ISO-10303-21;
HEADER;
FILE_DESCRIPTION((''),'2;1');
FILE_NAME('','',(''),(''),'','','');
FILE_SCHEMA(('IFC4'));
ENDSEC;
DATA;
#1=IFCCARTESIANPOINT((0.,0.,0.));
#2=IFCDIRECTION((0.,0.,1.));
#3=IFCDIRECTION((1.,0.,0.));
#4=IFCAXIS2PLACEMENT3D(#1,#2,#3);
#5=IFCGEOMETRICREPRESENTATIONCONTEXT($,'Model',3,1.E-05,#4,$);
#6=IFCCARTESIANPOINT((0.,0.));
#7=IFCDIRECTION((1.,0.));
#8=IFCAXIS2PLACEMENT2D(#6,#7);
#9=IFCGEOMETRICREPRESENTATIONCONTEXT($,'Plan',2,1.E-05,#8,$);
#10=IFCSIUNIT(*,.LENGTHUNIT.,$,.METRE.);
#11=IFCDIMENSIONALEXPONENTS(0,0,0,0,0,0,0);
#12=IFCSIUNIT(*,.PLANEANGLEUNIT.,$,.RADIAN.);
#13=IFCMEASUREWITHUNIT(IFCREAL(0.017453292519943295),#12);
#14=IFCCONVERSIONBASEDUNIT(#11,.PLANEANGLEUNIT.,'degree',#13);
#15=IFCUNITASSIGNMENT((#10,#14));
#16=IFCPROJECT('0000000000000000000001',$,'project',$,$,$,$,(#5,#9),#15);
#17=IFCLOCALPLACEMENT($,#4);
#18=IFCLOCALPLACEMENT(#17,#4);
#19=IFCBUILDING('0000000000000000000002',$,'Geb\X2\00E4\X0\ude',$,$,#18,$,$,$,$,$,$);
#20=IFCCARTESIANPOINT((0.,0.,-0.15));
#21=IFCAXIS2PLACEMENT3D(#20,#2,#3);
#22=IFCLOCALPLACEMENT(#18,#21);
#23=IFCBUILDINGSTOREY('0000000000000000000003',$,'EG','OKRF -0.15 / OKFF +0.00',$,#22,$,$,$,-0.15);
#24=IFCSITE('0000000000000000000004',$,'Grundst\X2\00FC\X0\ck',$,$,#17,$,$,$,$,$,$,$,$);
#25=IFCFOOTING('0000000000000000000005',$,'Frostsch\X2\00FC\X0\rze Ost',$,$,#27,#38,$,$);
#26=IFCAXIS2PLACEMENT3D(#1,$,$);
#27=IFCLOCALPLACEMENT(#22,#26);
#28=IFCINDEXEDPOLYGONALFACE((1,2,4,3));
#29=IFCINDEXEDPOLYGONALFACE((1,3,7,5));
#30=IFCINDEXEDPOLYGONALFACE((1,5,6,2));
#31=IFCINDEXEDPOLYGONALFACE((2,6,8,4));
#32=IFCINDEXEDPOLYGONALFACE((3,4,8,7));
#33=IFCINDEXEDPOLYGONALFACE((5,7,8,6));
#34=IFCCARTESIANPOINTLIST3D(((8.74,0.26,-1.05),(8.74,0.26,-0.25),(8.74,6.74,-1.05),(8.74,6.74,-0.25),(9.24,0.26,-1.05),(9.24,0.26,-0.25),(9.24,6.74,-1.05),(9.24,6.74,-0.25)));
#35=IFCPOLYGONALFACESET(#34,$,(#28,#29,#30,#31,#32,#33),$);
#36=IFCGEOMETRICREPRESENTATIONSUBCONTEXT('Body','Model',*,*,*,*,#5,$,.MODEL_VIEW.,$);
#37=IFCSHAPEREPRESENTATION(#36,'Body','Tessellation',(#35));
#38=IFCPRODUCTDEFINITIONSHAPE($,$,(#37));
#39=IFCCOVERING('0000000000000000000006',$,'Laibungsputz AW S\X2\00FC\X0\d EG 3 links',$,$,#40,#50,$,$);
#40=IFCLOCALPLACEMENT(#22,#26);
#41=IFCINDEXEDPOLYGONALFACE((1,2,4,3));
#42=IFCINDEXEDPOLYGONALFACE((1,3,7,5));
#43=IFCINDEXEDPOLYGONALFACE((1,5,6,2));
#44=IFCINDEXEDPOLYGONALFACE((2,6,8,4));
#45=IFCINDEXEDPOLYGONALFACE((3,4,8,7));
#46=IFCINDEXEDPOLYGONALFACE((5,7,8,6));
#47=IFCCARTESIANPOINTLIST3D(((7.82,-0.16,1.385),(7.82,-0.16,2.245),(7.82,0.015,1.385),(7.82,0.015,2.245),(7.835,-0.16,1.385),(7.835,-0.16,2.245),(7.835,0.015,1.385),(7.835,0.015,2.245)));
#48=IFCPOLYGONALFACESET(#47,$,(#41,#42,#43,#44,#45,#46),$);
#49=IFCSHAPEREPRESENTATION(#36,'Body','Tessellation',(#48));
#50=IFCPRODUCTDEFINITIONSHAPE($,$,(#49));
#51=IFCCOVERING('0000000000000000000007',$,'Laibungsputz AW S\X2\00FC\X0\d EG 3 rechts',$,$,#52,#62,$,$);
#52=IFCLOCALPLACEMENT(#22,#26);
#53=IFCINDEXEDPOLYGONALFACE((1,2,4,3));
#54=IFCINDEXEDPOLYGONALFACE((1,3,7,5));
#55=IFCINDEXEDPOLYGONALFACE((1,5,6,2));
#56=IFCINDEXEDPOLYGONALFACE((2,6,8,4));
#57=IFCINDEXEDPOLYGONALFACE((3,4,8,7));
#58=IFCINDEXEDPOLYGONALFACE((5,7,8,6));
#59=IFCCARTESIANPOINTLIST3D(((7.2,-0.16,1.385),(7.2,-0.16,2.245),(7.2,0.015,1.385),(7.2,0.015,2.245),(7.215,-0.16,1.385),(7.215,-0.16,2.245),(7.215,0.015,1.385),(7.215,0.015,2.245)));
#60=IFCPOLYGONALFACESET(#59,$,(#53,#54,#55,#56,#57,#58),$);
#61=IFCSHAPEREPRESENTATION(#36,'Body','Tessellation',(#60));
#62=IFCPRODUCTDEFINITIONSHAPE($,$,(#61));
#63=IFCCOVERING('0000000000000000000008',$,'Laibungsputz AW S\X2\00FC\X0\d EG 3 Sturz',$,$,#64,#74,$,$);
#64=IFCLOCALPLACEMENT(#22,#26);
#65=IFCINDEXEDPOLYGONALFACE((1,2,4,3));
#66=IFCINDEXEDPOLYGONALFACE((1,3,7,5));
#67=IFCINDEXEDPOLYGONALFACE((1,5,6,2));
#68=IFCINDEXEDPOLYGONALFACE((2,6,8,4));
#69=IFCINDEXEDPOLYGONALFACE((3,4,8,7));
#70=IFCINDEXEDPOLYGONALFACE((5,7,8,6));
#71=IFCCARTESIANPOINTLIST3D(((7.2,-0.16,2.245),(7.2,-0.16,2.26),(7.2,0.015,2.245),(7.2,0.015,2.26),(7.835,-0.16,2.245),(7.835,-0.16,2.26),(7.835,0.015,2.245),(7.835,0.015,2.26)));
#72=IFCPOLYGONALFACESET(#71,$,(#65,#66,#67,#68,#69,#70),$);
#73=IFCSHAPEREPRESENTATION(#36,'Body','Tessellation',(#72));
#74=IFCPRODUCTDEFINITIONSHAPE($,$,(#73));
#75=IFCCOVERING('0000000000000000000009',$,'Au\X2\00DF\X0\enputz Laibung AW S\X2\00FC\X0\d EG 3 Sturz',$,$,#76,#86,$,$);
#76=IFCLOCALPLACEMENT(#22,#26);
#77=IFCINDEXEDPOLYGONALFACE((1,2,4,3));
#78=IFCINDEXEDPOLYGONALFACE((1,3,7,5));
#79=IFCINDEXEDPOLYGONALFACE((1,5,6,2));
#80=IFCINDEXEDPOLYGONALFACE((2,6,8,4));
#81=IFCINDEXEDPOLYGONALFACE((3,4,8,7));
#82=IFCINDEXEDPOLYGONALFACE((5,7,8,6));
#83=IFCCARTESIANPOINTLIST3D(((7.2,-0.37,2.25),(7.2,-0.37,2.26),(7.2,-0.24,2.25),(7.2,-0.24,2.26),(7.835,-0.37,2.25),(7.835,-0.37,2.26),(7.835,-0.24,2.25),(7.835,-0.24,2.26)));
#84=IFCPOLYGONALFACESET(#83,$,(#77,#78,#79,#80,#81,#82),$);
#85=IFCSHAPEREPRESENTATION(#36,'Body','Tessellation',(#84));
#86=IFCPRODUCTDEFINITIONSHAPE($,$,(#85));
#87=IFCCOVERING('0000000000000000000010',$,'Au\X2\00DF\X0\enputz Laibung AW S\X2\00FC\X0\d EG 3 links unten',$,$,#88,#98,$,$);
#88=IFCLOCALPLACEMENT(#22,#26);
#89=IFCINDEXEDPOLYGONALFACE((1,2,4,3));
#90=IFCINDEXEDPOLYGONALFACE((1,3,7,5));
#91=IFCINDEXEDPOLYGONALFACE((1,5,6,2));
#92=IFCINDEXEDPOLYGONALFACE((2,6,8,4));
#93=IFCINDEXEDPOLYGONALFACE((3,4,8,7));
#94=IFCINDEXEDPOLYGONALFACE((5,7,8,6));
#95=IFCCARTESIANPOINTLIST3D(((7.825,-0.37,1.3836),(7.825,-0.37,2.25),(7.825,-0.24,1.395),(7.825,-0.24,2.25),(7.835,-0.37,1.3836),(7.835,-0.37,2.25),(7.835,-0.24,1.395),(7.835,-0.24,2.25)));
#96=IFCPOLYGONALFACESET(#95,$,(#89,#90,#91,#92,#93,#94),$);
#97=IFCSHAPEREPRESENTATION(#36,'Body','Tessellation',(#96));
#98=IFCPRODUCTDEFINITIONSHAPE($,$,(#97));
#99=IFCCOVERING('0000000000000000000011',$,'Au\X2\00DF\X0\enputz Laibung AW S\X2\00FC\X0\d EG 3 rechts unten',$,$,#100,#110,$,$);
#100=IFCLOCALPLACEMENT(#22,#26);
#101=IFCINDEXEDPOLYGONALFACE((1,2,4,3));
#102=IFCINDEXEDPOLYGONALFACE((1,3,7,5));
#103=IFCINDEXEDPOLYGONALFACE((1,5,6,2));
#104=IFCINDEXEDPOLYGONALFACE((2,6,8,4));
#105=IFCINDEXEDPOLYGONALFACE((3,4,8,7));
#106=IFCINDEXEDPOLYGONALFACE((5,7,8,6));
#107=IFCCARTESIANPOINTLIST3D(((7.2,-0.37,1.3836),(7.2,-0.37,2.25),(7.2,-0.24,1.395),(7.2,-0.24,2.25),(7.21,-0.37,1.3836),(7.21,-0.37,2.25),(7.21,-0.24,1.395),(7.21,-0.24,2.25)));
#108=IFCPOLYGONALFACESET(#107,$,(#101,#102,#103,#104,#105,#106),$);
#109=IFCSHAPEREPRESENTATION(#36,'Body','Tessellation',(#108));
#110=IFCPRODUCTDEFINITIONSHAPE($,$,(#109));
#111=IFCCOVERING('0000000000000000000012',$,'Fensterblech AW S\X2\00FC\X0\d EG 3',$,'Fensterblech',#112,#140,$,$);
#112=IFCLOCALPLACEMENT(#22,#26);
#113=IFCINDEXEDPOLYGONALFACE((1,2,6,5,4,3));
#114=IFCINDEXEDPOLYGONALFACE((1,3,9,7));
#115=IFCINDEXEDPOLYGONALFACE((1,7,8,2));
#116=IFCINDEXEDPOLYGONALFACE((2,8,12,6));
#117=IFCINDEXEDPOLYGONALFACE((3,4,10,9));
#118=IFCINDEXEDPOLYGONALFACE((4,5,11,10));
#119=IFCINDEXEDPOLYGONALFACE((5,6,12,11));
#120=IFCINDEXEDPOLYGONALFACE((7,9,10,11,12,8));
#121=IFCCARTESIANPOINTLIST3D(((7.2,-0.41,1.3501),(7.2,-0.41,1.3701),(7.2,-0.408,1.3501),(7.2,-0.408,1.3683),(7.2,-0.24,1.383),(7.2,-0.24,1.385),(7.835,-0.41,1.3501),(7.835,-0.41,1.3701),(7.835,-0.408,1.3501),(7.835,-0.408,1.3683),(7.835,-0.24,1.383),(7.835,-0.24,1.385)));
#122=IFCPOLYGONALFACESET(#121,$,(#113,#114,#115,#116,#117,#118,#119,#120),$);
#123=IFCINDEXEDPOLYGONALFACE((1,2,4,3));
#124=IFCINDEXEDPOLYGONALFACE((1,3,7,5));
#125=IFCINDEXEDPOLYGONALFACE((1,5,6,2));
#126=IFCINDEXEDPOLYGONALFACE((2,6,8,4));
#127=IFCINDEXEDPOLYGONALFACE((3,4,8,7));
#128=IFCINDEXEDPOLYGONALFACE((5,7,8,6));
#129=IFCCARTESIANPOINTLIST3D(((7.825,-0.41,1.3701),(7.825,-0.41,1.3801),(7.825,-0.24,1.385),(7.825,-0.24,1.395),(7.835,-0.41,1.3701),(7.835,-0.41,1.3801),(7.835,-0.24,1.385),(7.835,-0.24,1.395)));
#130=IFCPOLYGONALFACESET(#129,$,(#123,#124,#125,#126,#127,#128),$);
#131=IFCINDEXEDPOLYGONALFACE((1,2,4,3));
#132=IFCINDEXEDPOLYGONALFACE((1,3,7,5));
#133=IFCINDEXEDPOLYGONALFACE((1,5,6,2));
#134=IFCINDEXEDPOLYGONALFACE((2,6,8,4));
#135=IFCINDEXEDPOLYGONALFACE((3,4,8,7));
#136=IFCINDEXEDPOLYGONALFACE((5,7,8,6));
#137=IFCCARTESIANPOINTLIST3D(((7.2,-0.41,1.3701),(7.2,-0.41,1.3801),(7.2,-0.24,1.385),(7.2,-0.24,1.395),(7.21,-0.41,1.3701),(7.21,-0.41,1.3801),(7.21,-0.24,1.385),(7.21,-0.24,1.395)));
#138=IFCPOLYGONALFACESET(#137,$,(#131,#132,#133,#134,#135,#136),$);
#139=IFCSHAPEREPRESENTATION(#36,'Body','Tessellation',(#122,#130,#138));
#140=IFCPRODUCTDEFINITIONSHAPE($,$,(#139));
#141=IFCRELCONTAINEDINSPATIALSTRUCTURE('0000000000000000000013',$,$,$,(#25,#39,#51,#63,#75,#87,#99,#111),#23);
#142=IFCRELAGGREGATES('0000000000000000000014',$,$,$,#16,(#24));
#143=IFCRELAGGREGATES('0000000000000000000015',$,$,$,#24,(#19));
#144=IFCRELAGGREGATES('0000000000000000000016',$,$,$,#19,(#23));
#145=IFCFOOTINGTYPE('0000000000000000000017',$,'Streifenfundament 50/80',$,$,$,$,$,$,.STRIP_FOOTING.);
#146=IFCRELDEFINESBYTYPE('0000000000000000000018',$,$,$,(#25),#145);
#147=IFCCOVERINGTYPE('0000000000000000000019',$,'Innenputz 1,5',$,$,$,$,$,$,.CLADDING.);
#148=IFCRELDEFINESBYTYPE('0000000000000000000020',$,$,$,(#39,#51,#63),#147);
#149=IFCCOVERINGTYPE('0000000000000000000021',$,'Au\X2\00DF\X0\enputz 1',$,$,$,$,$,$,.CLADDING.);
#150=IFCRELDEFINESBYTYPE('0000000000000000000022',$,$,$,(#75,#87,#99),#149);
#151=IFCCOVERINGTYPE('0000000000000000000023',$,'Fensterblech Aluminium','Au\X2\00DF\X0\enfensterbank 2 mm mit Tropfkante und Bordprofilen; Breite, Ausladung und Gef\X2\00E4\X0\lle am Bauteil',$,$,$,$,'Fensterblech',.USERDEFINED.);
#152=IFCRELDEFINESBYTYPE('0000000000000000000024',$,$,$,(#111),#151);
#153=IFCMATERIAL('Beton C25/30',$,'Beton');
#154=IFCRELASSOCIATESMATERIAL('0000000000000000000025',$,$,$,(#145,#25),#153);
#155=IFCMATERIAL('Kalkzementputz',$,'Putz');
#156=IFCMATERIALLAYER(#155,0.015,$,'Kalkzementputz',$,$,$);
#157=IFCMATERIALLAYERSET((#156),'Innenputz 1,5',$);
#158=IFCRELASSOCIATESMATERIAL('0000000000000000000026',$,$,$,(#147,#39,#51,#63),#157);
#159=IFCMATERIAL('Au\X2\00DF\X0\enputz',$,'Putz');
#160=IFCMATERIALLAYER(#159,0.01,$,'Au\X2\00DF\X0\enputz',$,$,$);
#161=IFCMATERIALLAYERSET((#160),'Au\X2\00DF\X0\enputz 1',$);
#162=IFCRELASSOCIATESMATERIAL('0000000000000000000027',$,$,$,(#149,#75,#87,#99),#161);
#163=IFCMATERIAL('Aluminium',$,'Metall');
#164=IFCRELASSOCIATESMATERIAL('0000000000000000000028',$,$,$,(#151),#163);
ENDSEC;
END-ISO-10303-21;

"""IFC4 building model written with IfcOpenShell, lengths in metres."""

from ifc_helpers import new_model, entity, si_unit, converted_unit, frame, origin_with_axes, origin_2d_with_axis, place, context, subcontext, project, spatial, polyline, rectangle, outline, extrude, material, layer, layer_set, layer_usage, material_profile, profile_set, profile_usage, type_object, element, save


model = new_model("IFC4")

# Units and contexts
model_context = context("Model", 3, precision=1e-05, world=origin_with_axes())
plan_context = context("Plan", 2, precision=1e-05, world=origin_2d_with_axis())
body_context_1 = subcontext(model_context, "Body", "Model", "MODEL_VIEW")
ifc_project = project(units=[si_unit("LENGTHUNIT", "METRE"), converted_unit("PLANEANGLEUNIT", "degree", entity("IfcReal", 0.017453292519943295), si_unit("PLANEANGLEUNIT", "RADIAN"), dimensions=[0, 0, 0, 0, 0, 0, 0])], contexts=[model_context, plan_context])

# Site, building, storey
site_placement = place(None, origin_with_axes())
site = spatial("IfcSite", under=ifc_project, at=site_placement, Name="Grundstück")
building_placement = place(site_placement, origin_with_axes())
building = spatial("IfcBuilding", under=site, at=building_placement, Name="Gebäude")
storey_placement = place(building_placement, frame((0.0, 0.0, -0.15), z_axis=(0.0, 0.0, 1.0), x_axis=(1.0, 0.0, 0.0)))
storey = spatial("IfcBuildingStorey", under=building, at=storey_placement, Name="EG", Description="OKRF -0.15 / OKFF +0.00", Elevation=-0.15)

# Footing
ifc_material_1 = material(Name="Beton C25/30", Category="Beton")
ifc_material_profile = material_profile(ifc_material_1, rectangle(XDim=0.5, YDim=0.8))
ifc_profile_set = profile_set([ifc_material_profile], Name="Streifenfundament 50/80")
ifc_profile_usage = profile_usage(ifc_profile_set)
footing_type = type_object("IfcFootingType", Name="Streifenfundament 50/80", PredefinedType="STRIP_FOOTING", material=ifc_profile_set)
footing_placement = place(storey_placement, frame((8.99, 0.26, -0.65), z_axis=(0.0, 1.0, 0.0), x_axis=(-1.0, 0.0, 0.0)))
element("IfcFooting", 1, at=footing_placement, inside=storey, type_object=footing_type, material=ifc_profile_usage, Name="Frostschürze Ost", context=body_context_1, shape_type="SweptSolid", body=[
    extrude(rectangle(XDim=0.5, YDim=0.8), origin_with_axes(), (0.0, 0.0, 1.0), 6.48),
])

# Coverings
ifc_material_2 = material(Name="Kalkzementputz", Category="Putz")
ifc_layer_1 = layer(ifc_material_2, 0.015, Name="Kalkzementputz")
ifc_layer_set_1 = layer_set([ifc_layer_1], Name="Innenputz 1,5")
ifc_layer_usage_1 = layer_usage(ifc_layer_set_1, "AXIS1", "POSITIVE", 1.165)
covering_type_1 = type_object("IfcCoveringType", Name="Innenputz 1,5", PredefinedType="CLADDING", material=ifc_layer_set_1)
covering_1_placement = place(storey_placement, frame((9.0, 0.0, 0.0), z_axis=(0.0, 0.0, 1.0), x_axis=(-1.0, 0.0, 0.0)))
element("IfcCovering", 2, at=covering_1_placement, inside=storey, type_object=covering_type_1, material=ifc_layer_usage_1, Name="Laibungsputz AW Süd EG 3 links", context=body_context_1, shape_type="SweptSolid", body=[
    extrude(outline(polyline([(-0.015, 1.385), (0.16, 1.385), (0.16, 2.245), (-0.015, 2.245), (-0.015, 1.385)])), frame((1.165, 0.0, 0.0), z_axis=(1.0, 0.0, 0.0), x_axis=(0.0, 1.0, 0.0)), (0.0, 0.0, 1.0), 0.015),
])
ifc_layer_usage_2 = layer_usage(ifc_layer_set_1, "AXIS1", "POSITIVE", 1.785)
covering_2_placement = place(storey_placement, frame((9.0, 0.0, 0.0), z_axis=(0.0, 0.0, 1.0), x_axis=(-1.0, 0.0, 0.0)))
element("IfcCovering", 3, at=covering_2_placement, inside=storey, type_object=covering_type_1, material=ifc_layer_usage_2, Name="Laibungsputz AW Süd EG 3 rechts", context=body_context_1, shape_type="SweptSolid", body=[
    extrude(outline(polyline([(-0.015, 1.385), (0.16, 1.385), (0.16, 2.245), (-0.015, 2.245), (-0.015, 1.385)])), frame((1.785, 0.0, 0.0), z_axis=(1.0, 0.0, 0.0), x_axis=(0.0, 1.0, 0.0)), (0.0, 0.0, 1.0), 0.015),
])
ifc_layer_usage_3 = layer_usage(ifc_layer_set_1, "AXIS3", "POSITIVE", 2.245)
covering_3_placement = place(storey_placement, frame((9.0, 0.0, 0.0), z_axis=(0.0, 0.0, 1.0), x_axis=(-1.0, 0.0, 0.0)))
element("IfcCovering", 4, at=covering_3_placement, inside=storey, type_object=covering_type_1, material=ifc_layer_usage_3, Name="Laibungsputz AW Süd EG 3 Sturz", context=body_context_1, shape_type="SweptSolid", body=[
    extrude(outline(polyline([(-0.015, 2.245), (0.16, 2.245), (0.16, 2.26), (-0.015, 2.26), (-0.015, 2.245)])), frame((1.165, 0.0, 0.0), z_axis=(1.0, 0.0, 0.0), x_axis=(0.0, 1.0, 0.0)), (0.0, 0.0, 1.0), 0.635),
])
ifc_material_3 = material(Name="Außenputz", Category="Putz")
ifc_layer_2 = layer(ifc_material_3, 0.01, Name="Außenputz")
ifc_layer_set_2 = layer_set([ifc_layer_2], Name="Außenputz 1")
ifc_layer_usage_4 = layer_usage(ifc_layer_set_2, "AXIS3", "POSITIVE", 2.25)
covering_type_2 = type_object("IfcCoveringType", Name="Außenputz 1", PredefinedType="CLADDING", material=ifc_layer_set_2)
covering_4_placement = place(storey_placement, frame((9.0, 0.0, 0.0), z_axis=(0.0, 0.0, 1.0), x_axis=(-1.0, 0.0, 0.0)))
element("IfcCovering", 5, at=covering_4_placement, inside=storey, type_object=covering_type_2, material=ifc_layer_usage_4, Name="Außenputz Laibung AW Süd EG 3 Sturz", context=body_context_1, shape_type="SweptSolid", body=[
    extrude(outline(polyline([(0.24, 2.25), (0.37, 2.25), (0.37, 2.26), (0.24, 2.26), (0.24, 2.25)])), frame((1.165, 0.0, 0.0), z_axis=(1.0, 0.0, 0.0), x_axis=(0.0, 1.0, 0.0)), (0.0, 0.0, 1.0), 0.635),
])
ifc_layer_usage_5 = layer_usage(ifc_layer_set_2, "AXIS1", "POSITIVE", 1.165)
covering_5_placement = place(storey_placement, frame((9.0, 0.0, 0.0), z_axis=(0.0, 0.0, 1.0), x_axis=(-1.0, 0.0, 0.0)))
element("IfcCovering", 6, at=covering_5_placement, inside=storey, type_object=covering_type_2, material=ifc_layer_usage_5, Name="Außenputz Laibung AW Süd EG 3 links unten", context=body_context_1, shape_type="SweptSolid", body=[
    extrude(outline(polyline([(0.24, 1.395), (0.37, 1.3836), (0.37, 2.25), (0.24, 2.25), (0.24, 1.395)])), frame((1.165, 0.0, 0.0), z_axis=(1.0, 0.0, 0.0), x_axis=(0.0, 1.0, 0.0)), (0.0, 0.0, 1.0), 0.01),
])
ifc_layer_usage_6 = layer_usage(ifc_layer_set_2, "AXIS1", "POSITIVE", 1.79)
covering_6_placement = place(storey_placement, frame((9.0, 0.0, 0.0), z_axis=(0.0, 0.0, 1.0), x_axis=(-1.0, 0.0, 0.0)))
element("IfcCovering", 7, at=covering_6_placement, inside=storey, type_object=covering_type_2, material=ifc_layer_usage_6, Name="Außenputz Laibung AW Süd EG 3 rechts unten", context=body_context_1, shape_type="SweptSolid", body=[
    extrude(outline(polyline([(0.24, 1.395), (0.37, 1.3836), (0.37, 2.25), (0.24, 2.25), (0.24, 1.395)])), frame((1.79, 0.0, 0.0), z_axis=(1.0, 0.0, 0.0), x_axis=(0.0, 1.0, 0.0)), (0.0, 0.0, 1.0), 0.01),
])
ifc_material_4 = material(Name="Aluminium", Category="Metall")
covering_type_3 = type_object("IfcCoveringType", Name="Fensterblech Aluminium", Description="Außenfensterbank 2 mm mit Tropfkante und Bordprofilen; Breite, Ausladung und Gefälle am Bauteil", ElementType="Fensterblech", PredefinedType="USERDEFINED", material=ifc_material_4)
covering_7_placement = place(storey_placement, frame((9.0, 0.0, 0.0), z_axis=(0.0, 0.0, 1.0), x_axis=(-1.0, 0.0, 0.0)))
element("IfcCovering", 8, at=covering_7_placement, inside=storey, type_object=covering_type_3, Name="Fensterblech AW Süd EG 3", ObjectType="Fensterblech", context=body_context_1, shape_type="SweptSolid", body=[
    extrude(outline(polyline([(0.24, 1.383), (0.408, 1.3683), (0.408, 1.3501), (0.41, 1.3501), (0.41, 1.3701), (0.24, 1.385), (0.24, 1.383)])), frame((1.165, 0.0, 0.0), z_axis=(1.0, 0.0, 0.0), x_axis=(0.0, 1.0, 0.0)), (0.0, 0.0, 1.0), 0.635),
    extrude(outline(polyline([(0.24, 1.385), (0.41, 1.3701), (0.41, 1.3801), (0.24, 1.395), (0.24, 1.385)])), frame((1.165, 0.0, 0.0), z_axis=(1.0, 0.0, 0.0), x_axis=(0.0, 1.0, 0.0)), (0.0, 0.0, 1.0), 0.01),
    extrude(outline(polyline([(0.24, 1.385), (0.41, 1.3701), (0.41, 1.3801), (0.24, 1.395), (0.24, 1.385)])), frame((1.79, 0.0, 0.0), z_axis=(1.0, 0.0, 0.0), x_axis=(0.0, 1.0, 0.0)), (0.0, 0.0, 1.0), 0.01),
])

save(model, "model.ifc")
